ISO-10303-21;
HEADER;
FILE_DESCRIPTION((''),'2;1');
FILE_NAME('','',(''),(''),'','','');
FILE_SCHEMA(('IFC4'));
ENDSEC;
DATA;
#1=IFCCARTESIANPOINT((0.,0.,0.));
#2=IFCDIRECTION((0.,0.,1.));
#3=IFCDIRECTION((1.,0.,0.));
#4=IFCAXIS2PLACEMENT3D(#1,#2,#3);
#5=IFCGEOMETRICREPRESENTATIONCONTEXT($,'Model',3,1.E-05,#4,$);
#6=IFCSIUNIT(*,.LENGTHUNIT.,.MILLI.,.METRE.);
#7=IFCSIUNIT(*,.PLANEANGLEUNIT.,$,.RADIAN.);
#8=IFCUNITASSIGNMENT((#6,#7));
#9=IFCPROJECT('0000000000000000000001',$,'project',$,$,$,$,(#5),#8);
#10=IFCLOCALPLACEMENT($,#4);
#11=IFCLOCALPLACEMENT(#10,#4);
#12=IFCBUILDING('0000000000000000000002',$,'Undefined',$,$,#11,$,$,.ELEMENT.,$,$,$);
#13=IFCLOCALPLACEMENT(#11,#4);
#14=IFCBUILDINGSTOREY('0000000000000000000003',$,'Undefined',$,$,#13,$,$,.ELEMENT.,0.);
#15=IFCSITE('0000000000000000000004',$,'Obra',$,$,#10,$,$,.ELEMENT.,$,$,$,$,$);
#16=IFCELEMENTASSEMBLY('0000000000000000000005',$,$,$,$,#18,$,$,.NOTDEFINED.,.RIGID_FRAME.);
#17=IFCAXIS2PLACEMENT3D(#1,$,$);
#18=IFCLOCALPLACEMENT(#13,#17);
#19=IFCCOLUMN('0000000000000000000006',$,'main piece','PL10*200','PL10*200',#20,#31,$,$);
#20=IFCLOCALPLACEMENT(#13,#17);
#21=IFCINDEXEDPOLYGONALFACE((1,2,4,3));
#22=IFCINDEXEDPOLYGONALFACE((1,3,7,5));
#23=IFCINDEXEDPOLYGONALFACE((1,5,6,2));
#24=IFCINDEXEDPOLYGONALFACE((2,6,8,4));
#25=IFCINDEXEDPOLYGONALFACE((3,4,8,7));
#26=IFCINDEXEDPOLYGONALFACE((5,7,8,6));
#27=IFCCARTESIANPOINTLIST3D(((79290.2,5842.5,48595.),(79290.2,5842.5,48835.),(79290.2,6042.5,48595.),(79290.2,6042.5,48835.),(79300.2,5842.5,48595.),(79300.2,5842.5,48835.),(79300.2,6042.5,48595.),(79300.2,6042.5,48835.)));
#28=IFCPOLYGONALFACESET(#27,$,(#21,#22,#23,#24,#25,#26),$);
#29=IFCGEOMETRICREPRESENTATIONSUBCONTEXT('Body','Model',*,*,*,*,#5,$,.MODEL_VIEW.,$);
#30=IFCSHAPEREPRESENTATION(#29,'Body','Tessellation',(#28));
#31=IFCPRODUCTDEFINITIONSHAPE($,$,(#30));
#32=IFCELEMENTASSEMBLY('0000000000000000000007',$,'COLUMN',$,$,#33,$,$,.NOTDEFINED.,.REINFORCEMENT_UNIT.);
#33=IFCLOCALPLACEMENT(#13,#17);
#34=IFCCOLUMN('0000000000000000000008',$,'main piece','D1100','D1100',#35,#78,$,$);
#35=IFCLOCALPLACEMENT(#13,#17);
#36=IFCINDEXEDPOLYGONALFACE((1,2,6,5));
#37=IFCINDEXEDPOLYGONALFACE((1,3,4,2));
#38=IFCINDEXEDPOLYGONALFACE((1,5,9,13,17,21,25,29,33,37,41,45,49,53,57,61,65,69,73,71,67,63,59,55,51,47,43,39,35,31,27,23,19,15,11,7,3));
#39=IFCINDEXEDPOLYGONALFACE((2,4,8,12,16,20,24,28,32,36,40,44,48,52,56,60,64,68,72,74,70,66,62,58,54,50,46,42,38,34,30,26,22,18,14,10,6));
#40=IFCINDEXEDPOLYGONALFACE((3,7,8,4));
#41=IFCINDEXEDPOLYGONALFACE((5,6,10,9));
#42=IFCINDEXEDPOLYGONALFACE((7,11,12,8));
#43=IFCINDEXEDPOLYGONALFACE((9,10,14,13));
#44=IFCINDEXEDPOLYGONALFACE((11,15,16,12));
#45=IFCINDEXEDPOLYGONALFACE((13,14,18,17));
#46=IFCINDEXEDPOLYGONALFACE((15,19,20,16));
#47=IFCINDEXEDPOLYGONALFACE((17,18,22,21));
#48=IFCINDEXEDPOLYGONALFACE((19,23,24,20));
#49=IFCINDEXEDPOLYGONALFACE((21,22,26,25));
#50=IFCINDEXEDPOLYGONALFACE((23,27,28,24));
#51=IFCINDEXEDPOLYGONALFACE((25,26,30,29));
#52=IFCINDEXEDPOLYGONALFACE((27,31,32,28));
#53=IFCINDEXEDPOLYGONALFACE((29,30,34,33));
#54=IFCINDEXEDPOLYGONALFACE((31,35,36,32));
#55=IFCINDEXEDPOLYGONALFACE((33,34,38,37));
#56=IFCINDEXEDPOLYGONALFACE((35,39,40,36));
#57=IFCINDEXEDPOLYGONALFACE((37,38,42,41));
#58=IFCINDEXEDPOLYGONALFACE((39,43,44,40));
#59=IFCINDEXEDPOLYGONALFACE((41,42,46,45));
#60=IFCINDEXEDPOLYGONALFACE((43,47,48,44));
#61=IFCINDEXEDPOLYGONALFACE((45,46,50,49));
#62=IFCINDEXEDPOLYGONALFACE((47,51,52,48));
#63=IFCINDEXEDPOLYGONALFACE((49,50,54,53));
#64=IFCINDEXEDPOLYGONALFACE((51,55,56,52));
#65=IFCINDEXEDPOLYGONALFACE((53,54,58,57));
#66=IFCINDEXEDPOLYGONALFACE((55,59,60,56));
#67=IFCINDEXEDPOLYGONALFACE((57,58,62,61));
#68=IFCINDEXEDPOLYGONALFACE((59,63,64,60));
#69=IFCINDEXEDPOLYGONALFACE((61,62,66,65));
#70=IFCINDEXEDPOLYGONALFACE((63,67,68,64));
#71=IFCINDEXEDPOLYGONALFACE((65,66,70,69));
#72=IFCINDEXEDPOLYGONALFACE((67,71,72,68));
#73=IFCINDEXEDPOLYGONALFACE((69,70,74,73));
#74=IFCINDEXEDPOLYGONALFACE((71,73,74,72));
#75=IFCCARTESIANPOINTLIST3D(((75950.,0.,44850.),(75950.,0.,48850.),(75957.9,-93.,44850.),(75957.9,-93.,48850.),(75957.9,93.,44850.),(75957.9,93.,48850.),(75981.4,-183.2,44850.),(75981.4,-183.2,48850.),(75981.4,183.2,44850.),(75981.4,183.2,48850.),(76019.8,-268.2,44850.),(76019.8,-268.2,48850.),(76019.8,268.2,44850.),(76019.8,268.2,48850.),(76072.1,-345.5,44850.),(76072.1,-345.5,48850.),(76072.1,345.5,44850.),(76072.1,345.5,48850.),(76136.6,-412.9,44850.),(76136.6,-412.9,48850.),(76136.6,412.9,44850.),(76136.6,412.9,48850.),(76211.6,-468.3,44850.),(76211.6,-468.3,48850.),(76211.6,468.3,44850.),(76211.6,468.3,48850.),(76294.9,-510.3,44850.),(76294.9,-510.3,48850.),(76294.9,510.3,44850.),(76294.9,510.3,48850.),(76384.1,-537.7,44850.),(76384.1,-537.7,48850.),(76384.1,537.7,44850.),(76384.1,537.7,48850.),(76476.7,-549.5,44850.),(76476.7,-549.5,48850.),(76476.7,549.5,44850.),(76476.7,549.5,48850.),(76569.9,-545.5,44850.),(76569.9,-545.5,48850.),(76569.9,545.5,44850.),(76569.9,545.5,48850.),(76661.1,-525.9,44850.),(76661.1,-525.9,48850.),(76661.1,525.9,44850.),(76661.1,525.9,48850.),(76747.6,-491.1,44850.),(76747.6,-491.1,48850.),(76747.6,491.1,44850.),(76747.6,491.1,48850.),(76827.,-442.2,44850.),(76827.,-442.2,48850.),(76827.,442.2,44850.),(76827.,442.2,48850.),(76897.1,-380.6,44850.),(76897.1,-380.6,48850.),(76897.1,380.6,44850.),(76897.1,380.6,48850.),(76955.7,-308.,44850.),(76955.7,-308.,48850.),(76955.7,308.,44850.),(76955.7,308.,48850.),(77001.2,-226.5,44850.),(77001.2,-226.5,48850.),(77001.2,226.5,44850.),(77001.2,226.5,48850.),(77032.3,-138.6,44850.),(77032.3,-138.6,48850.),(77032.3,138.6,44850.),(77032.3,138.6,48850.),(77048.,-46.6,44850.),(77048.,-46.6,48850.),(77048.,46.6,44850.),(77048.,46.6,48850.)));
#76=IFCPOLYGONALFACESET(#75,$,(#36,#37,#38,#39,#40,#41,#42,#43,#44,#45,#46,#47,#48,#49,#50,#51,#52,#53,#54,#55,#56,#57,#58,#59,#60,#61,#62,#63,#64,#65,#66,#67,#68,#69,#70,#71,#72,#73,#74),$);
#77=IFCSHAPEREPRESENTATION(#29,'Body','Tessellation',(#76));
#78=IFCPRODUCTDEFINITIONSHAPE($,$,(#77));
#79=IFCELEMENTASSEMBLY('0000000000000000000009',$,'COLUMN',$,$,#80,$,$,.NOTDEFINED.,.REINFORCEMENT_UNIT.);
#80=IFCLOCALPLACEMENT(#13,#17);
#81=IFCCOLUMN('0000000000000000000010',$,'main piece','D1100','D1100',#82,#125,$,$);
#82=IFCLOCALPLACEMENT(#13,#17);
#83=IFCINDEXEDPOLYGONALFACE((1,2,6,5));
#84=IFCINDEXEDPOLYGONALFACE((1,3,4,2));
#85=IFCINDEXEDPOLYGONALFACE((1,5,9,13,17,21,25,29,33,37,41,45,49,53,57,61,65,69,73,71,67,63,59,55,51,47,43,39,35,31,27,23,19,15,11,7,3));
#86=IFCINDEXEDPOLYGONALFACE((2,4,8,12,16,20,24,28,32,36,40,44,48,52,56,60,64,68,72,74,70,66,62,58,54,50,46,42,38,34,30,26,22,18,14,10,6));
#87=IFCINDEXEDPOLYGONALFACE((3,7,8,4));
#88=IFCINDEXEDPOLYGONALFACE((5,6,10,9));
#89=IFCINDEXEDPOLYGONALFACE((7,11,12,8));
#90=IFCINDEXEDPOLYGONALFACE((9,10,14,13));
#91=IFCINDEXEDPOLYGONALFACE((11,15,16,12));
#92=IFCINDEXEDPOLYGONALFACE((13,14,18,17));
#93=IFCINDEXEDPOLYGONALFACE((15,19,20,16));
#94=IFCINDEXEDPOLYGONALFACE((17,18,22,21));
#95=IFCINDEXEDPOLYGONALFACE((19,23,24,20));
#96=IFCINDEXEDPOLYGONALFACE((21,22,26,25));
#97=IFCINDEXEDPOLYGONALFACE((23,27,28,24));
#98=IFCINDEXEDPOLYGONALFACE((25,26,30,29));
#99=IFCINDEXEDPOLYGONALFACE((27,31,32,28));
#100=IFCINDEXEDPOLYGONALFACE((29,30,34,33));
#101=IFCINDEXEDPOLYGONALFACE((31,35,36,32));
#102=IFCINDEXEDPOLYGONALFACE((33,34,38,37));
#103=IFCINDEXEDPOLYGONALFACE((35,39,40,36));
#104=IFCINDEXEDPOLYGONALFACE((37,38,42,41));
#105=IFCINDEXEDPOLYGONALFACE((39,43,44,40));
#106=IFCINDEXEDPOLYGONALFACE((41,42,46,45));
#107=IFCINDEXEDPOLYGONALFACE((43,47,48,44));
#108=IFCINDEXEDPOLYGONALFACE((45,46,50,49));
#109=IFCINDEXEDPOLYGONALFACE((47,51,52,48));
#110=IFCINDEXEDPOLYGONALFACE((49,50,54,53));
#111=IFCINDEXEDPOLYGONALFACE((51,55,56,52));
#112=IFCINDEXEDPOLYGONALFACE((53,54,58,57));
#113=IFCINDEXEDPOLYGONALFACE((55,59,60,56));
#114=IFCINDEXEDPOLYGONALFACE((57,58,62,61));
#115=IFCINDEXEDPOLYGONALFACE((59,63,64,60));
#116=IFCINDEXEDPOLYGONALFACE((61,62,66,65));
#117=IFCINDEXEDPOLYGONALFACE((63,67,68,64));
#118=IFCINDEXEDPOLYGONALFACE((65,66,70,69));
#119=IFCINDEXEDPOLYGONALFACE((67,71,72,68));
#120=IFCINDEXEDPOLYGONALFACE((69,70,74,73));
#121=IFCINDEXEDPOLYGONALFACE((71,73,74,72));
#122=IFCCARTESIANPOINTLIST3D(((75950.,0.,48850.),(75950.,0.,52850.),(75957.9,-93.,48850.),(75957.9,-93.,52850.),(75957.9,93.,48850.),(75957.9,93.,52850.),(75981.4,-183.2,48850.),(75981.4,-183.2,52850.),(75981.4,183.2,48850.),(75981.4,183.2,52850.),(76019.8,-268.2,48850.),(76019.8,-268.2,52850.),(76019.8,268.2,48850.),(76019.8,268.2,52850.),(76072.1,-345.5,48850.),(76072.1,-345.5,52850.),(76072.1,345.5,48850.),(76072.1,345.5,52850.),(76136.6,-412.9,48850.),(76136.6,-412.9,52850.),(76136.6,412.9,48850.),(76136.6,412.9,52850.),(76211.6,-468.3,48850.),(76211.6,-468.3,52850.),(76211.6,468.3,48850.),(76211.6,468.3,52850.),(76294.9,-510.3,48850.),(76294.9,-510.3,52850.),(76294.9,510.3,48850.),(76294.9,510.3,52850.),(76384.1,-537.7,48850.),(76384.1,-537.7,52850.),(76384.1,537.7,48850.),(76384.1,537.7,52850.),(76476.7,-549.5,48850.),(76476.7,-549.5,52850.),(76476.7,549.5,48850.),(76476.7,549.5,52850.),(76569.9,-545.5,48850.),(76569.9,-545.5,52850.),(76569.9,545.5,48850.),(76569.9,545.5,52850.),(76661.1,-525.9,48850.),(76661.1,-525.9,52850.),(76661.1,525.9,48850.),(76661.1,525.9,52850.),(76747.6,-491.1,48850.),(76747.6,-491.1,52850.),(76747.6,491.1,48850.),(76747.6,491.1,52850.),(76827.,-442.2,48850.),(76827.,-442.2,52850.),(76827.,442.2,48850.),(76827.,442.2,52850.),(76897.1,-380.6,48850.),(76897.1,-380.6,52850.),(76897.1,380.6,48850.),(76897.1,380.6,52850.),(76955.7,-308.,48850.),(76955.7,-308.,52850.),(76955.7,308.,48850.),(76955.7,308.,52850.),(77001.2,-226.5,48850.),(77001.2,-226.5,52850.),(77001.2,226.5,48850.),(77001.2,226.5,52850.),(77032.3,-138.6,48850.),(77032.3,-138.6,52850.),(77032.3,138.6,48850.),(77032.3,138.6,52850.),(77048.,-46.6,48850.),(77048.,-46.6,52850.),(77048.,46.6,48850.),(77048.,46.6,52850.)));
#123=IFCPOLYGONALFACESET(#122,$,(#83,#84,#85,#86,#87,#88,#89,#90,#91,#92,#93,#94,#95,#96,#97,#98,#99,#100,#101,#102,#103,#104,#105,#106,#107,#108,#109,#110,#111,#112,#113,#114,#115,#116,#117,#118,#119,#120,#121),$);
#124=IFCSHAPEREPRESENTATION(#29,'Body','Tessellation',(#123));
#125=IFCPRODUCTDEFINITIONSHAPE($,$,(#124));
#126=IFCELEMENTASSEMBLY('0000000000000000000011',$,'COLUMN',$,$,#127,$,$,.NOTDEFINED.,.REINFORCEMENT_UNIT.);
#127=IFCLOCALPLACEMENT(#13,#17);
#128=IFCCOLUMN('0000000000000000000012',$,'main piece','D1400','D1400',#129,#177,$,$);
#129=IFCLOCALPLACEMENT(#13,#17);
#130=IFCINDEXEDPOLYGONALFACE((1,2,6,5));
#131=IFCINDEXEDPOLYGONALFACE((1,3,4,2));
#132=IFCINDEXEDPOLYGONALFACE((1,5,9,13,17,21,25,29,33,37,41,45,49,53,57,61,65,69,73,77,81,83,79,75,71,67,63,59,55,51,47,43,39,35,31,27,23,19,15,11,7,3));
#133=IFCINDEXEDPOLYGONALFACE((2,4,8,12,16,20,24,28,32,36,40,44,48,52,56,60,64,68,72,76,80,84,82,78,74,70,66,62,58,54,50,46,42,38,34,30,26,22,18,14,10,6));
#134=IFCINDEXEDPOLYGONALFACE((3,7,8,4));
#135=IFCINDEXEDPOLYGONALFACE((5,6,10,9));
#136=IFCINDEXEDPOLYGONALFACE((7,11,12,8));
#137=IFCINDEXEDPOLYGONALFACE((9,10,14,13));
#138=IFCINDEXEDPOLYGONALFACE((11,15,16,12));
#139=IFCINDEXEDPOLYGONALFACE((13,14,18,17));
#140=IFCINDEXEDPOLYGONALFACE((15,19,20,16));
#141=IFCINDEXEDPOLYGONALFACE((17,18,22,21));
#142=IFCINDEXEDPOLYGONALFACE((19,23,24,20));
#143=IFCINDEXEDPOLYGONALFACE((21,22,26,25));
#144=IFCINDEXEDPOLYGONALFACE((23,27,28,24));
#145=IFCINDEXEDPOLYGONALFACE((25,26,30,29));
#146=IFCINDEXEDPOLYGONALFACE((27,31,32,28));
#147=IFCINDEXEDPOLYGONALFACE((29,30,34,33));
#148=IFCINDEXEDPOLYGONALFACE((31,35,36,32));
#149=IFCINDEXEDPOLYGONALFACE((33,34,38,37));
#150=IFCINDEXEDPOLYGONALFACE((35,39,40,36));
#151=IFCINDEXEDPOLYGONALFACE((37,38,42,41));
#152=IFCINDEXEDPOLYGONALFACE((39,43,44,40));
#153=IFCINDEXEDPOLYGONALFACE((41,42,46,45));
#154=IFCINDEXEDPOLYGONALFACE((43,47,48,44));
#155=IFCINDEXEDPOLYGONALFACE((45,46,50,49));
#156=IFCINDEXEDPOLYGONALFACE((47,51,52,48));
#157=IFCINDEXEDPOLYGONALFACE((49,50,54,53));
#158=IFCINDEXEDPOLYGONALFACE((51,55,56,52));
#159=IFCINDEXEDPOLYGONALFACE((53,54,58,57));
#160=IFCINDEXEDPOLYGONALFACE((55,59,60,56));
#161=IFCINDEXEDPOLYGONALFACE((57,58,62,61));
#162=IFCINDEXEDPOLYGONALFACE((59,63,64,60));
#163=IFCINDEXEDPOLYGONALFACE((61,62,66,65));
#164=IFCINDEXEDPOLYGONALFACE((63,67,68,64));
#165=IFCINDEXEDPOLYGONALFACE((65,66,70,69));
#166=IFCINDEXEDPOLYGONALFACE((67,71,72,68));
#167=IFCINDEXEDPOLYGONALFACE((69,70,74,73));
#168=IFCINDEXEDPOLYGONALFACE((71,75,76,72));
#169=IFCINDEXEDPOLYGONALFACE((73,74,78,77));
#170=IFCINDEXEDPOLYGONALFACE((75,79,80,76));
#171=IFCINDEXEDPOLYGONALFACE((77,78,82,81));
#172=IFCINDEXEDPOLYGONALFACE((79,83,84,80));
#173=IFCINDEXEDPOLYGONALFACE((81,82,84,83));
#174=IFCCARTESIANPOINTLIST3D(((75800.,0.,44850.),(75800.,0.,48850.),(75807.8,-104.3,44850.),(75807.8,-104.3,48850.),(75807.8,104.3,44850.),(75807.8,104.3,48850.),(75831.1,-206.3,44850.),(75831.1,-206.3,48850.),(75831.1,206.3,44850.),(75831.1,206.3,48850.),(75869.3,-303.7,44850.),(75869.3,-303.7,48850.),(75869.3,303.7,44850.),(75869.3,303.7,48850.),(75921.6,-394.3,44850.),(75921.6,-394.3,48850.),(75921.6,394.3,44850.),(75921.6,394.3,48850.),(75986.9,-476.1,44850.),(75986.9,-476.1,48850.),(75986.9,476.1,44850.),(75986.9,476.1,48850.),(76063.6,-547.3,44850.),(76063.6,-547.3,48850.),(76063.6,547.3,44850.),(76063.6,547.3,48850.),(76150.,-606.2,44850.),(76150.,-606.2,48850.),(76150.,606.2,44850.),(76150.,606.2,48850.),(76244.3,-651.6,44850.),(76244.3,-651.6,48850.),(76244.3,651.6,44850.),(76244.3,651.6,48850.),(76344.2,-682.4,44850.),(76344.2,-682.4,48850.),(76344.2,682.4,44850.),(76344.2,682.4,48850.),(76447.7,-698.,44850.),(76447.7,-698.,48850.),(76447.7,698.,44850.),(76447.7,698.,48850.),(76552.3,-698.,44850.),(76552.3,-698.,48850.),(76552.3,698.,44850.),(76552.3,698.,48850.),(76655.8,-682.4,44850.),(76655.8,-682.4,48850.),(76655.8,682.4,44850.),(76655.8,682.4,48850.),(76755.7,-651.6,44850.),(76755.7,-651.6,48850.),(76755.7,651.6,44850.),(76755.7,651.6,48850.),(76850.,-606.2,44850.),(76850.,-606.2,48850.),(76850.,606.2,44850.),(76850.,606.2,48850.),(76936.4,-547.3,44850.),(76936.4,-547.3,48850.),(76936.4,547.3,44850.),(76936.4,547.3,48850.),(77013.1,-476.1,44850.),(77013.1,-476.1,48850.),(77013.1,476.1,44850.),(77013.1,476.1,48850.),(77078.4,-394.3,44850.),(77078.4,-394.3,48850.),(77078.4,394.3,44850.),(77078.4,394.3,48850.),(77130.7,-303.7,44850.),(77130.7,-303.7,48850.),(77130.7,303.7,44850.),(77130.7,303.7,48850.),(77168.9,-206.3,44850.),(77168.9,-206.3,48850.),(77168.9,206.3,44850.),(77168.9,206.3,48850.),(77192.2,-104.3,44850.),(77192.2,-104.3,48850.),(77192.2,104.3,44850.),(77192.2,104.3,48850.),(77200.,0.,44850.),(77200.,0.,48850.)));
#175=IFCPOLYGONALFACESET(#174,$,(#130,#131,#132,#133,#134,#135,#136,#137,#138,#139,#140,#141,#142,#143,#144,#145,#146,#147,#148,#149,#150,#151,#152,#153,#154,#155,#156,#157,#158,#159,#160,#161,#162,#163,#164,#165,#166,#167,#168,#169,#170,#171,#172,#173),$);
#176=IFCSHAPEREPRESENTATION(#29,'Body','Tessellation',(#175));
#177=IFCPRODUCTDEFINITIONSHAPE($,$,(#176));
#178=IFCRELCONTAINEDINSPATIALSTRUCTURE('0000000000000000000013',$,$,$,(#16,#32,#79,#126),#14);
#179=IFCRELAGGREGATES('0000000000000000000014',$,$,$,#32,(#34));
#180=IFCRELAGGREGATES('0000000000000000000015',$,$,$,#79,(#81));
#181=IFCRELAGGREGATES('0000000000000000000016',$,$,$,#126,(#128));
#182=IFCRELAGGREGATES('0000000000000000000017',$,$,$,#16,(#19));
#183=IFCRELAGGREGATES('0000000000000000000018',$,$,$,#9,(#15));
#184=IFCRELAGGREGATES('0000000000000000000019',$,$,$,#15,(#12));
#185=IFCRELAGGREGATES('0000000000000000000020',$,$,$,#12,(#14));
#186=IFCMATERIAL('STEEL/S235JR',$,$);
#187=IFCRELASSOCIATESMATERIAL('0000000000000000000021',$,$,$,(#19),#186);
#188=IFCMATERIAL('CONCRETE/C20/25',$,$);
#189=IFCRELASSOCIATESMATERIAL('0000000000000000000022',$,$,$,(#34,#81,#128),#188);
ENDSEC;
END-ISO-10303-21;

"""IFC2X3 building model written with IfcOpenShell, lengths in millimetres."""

from ifc_helpers import new_model, si_unit, frame, origin_with_axes, origin_2d_with_axis, place, context, subcontext, project, spatial, rectangle, circle, extrude, material, element, aggregate, save


model = new_model("IFC2X3")

# Units and contexts
model_context = context("Model", 3, precision=1e-05, world=origin_with_axes())
body_context = subcontext(model_context, "Body", "Model", "MODEL_VIEW")
ifc_project = project(units=[si_unit("LENGTHUNIT", "METRE", prefix="MILLI"), si_unit("PLANEANGLEUNIT", "RADIAN")], contexts=[model_context])

# Site, building, storey
site_placement = place(None, origin_with_axes())
site = spatial("IfcSite", under=ifc_project, at=site_placement, Name="Obra", CompositionType="ELEMENT")
building_placement = place(site_placement, origin_with_axes())
building = spatial("IfcBuilding", under=site, at=building_placement, Name="Undefined", CompositionType="ELEMENT")
storey_placement = place(building_placement, origin_with_axes())
storey = spatial("IfcBuildingStorey", under=building, at=storey_placement, Name="Undefined", CompositionType="ELEMENT", Elevation=0.0)

# Element assemblies, columns
assembly_1_placement = place(storey_placement, origin_with_axes())
assembly_1 = element("IfcElementAssembly", 1, at=assembly_1_placement, inside=storey, AssemblyPlace="NOTDEFINED", PredefinedType="RIGID_FRAME")
ifc_material_1 = material(Name="STEEL/S235JR")
column_1_placement = place(assembly_1_placement, frame((79295.2, 5942.5, 48595.0), z_axis=(0.0, 0.0, 1.0), x_axis=(0.0, -1.0, 0.0)))
column_1 = element("IfcColumn", 2, at=column_1_placement, material=ifc_material_1, Name="main piece", Description="PL10*200", ObjectType="PL10*200", context=body_context, shape_type="SweptSolid", body=[
    extrude(rectangle(XDim=10.0, YDim=200.0, at=origin_2d_with_axis()), frame((0.0, 0.0, 240.0), z_axis=(0.0, 0.0, -1.0), x_axis=(0.0, 1.0, 0.0)), (0.0, 0.0, 1.0), 240.0),
])
assembly_2_placement = place(storey_placement, origin_with_axes())
assembly_2 = element("IfcElementAssembly", 3, at=assembly_2_placement, inside=storey, Name="COLUMN", AssemblyPlace="NOTDEFINED", PredefinedType="REINFORCEMENT_UNIT")
ifc_material_2 = material(Name="CONCRETE/C20/25")
column_2_placement = place(assembly_2_placement, frame((76500.0, 0.0, 44850.0), z_axis=(0.0, 0.0, 1.0), x_axis=(0.0, 1.0, 0.0)))
column_2 = element("IfcColumn", 4, at=column_2_placement, material=ifc_material_2, Name="main piece", Description="D1100", ObjectType="D1100", context=body_context, shape_type="SweptSolid", body=[
    extrude(circle(Radius=550.0, at=origin_2d_with_axis()), frame((0.0, 0.0, 4000.0), z_axis=(0.0, 0.0, -1.0), x_axis=(0.0, 1.0, 0.0)), (0.0, 0.0, 1.0), 4000.0),
])
aggregate(assembly_2, [column_2])
assembly_3_placement = place(storey_placement, origin_with_axes())
assembly_3 = element("IfcElementAssembly", 5, at=assembly_3_placement, inside=storey, Name="COLUMN", AssemblyPlace="NOTDEFINED", PredefinedType="REINFORCEMENT_UNIT")
column_3_placement = place(assembly_3_placement, frame((76500.0, 0.0, 48850.0), z_axis=(0.0, 0.0, 1.0), x_axis=(0.0, 1.0, 0.0)))
column_3 = element("IfcColumn", 6, at=column_3_placement, material=ifc_material_2, Name="main piece", Description="D1100", ObjectType="D1100", context=body_context, shape_type="SweptSolid", body=[
    extrude(circle(Radius=550.0, at=origin_2d_with_axis()), frame((0.0, 0.0, 4000.0), z_axis=(0.0, 0.0, -1.0), x_axis=(0.0, 1.0, 0.0)), (0.0, 0.0, 1.0), 4000.0),
])
aggregate(assembly_3, [column_3])
assembly_4_placement = place(storey_placement, origin_with_axes())
assembly_4 = element("IfcElementAssembly", 7, at=assembly_4_placement, inside=storey, Name="COLUMN", AssemblyPlace="NOTDEFINED", PredefinedType="REINFORCEMENT_UNIT")
column_4_placement = place(assembly_4_placement, frame((76500.0, 0.0, 44850.0), z_axis=(0.0, 0.0, 1.0), x_axis=(0.0, 1.0, 0.0)))
column_4 = element("IfcColumn", 8, at=column_4_placement, material=ifc_material_2, Name="main piece", Description="D1400", ObjectType="D1400", context=body_context, shape_type="SweptSolid", body=[
    extrude(circle(Radius=700.0, at=origin_2d_with_axis()), frame((0.0, 0.0, 4000.0), z_axis=(0.0, 0.0, -1.0), x_axis=(0.0, 1.0, 0.0)), (0.0, 0.0, 1.0), 4000.0),
])
aggregate(assembly_4, [column_4])

aggregate(assembly_1, [column_1])

save(model, "model.ifc")
